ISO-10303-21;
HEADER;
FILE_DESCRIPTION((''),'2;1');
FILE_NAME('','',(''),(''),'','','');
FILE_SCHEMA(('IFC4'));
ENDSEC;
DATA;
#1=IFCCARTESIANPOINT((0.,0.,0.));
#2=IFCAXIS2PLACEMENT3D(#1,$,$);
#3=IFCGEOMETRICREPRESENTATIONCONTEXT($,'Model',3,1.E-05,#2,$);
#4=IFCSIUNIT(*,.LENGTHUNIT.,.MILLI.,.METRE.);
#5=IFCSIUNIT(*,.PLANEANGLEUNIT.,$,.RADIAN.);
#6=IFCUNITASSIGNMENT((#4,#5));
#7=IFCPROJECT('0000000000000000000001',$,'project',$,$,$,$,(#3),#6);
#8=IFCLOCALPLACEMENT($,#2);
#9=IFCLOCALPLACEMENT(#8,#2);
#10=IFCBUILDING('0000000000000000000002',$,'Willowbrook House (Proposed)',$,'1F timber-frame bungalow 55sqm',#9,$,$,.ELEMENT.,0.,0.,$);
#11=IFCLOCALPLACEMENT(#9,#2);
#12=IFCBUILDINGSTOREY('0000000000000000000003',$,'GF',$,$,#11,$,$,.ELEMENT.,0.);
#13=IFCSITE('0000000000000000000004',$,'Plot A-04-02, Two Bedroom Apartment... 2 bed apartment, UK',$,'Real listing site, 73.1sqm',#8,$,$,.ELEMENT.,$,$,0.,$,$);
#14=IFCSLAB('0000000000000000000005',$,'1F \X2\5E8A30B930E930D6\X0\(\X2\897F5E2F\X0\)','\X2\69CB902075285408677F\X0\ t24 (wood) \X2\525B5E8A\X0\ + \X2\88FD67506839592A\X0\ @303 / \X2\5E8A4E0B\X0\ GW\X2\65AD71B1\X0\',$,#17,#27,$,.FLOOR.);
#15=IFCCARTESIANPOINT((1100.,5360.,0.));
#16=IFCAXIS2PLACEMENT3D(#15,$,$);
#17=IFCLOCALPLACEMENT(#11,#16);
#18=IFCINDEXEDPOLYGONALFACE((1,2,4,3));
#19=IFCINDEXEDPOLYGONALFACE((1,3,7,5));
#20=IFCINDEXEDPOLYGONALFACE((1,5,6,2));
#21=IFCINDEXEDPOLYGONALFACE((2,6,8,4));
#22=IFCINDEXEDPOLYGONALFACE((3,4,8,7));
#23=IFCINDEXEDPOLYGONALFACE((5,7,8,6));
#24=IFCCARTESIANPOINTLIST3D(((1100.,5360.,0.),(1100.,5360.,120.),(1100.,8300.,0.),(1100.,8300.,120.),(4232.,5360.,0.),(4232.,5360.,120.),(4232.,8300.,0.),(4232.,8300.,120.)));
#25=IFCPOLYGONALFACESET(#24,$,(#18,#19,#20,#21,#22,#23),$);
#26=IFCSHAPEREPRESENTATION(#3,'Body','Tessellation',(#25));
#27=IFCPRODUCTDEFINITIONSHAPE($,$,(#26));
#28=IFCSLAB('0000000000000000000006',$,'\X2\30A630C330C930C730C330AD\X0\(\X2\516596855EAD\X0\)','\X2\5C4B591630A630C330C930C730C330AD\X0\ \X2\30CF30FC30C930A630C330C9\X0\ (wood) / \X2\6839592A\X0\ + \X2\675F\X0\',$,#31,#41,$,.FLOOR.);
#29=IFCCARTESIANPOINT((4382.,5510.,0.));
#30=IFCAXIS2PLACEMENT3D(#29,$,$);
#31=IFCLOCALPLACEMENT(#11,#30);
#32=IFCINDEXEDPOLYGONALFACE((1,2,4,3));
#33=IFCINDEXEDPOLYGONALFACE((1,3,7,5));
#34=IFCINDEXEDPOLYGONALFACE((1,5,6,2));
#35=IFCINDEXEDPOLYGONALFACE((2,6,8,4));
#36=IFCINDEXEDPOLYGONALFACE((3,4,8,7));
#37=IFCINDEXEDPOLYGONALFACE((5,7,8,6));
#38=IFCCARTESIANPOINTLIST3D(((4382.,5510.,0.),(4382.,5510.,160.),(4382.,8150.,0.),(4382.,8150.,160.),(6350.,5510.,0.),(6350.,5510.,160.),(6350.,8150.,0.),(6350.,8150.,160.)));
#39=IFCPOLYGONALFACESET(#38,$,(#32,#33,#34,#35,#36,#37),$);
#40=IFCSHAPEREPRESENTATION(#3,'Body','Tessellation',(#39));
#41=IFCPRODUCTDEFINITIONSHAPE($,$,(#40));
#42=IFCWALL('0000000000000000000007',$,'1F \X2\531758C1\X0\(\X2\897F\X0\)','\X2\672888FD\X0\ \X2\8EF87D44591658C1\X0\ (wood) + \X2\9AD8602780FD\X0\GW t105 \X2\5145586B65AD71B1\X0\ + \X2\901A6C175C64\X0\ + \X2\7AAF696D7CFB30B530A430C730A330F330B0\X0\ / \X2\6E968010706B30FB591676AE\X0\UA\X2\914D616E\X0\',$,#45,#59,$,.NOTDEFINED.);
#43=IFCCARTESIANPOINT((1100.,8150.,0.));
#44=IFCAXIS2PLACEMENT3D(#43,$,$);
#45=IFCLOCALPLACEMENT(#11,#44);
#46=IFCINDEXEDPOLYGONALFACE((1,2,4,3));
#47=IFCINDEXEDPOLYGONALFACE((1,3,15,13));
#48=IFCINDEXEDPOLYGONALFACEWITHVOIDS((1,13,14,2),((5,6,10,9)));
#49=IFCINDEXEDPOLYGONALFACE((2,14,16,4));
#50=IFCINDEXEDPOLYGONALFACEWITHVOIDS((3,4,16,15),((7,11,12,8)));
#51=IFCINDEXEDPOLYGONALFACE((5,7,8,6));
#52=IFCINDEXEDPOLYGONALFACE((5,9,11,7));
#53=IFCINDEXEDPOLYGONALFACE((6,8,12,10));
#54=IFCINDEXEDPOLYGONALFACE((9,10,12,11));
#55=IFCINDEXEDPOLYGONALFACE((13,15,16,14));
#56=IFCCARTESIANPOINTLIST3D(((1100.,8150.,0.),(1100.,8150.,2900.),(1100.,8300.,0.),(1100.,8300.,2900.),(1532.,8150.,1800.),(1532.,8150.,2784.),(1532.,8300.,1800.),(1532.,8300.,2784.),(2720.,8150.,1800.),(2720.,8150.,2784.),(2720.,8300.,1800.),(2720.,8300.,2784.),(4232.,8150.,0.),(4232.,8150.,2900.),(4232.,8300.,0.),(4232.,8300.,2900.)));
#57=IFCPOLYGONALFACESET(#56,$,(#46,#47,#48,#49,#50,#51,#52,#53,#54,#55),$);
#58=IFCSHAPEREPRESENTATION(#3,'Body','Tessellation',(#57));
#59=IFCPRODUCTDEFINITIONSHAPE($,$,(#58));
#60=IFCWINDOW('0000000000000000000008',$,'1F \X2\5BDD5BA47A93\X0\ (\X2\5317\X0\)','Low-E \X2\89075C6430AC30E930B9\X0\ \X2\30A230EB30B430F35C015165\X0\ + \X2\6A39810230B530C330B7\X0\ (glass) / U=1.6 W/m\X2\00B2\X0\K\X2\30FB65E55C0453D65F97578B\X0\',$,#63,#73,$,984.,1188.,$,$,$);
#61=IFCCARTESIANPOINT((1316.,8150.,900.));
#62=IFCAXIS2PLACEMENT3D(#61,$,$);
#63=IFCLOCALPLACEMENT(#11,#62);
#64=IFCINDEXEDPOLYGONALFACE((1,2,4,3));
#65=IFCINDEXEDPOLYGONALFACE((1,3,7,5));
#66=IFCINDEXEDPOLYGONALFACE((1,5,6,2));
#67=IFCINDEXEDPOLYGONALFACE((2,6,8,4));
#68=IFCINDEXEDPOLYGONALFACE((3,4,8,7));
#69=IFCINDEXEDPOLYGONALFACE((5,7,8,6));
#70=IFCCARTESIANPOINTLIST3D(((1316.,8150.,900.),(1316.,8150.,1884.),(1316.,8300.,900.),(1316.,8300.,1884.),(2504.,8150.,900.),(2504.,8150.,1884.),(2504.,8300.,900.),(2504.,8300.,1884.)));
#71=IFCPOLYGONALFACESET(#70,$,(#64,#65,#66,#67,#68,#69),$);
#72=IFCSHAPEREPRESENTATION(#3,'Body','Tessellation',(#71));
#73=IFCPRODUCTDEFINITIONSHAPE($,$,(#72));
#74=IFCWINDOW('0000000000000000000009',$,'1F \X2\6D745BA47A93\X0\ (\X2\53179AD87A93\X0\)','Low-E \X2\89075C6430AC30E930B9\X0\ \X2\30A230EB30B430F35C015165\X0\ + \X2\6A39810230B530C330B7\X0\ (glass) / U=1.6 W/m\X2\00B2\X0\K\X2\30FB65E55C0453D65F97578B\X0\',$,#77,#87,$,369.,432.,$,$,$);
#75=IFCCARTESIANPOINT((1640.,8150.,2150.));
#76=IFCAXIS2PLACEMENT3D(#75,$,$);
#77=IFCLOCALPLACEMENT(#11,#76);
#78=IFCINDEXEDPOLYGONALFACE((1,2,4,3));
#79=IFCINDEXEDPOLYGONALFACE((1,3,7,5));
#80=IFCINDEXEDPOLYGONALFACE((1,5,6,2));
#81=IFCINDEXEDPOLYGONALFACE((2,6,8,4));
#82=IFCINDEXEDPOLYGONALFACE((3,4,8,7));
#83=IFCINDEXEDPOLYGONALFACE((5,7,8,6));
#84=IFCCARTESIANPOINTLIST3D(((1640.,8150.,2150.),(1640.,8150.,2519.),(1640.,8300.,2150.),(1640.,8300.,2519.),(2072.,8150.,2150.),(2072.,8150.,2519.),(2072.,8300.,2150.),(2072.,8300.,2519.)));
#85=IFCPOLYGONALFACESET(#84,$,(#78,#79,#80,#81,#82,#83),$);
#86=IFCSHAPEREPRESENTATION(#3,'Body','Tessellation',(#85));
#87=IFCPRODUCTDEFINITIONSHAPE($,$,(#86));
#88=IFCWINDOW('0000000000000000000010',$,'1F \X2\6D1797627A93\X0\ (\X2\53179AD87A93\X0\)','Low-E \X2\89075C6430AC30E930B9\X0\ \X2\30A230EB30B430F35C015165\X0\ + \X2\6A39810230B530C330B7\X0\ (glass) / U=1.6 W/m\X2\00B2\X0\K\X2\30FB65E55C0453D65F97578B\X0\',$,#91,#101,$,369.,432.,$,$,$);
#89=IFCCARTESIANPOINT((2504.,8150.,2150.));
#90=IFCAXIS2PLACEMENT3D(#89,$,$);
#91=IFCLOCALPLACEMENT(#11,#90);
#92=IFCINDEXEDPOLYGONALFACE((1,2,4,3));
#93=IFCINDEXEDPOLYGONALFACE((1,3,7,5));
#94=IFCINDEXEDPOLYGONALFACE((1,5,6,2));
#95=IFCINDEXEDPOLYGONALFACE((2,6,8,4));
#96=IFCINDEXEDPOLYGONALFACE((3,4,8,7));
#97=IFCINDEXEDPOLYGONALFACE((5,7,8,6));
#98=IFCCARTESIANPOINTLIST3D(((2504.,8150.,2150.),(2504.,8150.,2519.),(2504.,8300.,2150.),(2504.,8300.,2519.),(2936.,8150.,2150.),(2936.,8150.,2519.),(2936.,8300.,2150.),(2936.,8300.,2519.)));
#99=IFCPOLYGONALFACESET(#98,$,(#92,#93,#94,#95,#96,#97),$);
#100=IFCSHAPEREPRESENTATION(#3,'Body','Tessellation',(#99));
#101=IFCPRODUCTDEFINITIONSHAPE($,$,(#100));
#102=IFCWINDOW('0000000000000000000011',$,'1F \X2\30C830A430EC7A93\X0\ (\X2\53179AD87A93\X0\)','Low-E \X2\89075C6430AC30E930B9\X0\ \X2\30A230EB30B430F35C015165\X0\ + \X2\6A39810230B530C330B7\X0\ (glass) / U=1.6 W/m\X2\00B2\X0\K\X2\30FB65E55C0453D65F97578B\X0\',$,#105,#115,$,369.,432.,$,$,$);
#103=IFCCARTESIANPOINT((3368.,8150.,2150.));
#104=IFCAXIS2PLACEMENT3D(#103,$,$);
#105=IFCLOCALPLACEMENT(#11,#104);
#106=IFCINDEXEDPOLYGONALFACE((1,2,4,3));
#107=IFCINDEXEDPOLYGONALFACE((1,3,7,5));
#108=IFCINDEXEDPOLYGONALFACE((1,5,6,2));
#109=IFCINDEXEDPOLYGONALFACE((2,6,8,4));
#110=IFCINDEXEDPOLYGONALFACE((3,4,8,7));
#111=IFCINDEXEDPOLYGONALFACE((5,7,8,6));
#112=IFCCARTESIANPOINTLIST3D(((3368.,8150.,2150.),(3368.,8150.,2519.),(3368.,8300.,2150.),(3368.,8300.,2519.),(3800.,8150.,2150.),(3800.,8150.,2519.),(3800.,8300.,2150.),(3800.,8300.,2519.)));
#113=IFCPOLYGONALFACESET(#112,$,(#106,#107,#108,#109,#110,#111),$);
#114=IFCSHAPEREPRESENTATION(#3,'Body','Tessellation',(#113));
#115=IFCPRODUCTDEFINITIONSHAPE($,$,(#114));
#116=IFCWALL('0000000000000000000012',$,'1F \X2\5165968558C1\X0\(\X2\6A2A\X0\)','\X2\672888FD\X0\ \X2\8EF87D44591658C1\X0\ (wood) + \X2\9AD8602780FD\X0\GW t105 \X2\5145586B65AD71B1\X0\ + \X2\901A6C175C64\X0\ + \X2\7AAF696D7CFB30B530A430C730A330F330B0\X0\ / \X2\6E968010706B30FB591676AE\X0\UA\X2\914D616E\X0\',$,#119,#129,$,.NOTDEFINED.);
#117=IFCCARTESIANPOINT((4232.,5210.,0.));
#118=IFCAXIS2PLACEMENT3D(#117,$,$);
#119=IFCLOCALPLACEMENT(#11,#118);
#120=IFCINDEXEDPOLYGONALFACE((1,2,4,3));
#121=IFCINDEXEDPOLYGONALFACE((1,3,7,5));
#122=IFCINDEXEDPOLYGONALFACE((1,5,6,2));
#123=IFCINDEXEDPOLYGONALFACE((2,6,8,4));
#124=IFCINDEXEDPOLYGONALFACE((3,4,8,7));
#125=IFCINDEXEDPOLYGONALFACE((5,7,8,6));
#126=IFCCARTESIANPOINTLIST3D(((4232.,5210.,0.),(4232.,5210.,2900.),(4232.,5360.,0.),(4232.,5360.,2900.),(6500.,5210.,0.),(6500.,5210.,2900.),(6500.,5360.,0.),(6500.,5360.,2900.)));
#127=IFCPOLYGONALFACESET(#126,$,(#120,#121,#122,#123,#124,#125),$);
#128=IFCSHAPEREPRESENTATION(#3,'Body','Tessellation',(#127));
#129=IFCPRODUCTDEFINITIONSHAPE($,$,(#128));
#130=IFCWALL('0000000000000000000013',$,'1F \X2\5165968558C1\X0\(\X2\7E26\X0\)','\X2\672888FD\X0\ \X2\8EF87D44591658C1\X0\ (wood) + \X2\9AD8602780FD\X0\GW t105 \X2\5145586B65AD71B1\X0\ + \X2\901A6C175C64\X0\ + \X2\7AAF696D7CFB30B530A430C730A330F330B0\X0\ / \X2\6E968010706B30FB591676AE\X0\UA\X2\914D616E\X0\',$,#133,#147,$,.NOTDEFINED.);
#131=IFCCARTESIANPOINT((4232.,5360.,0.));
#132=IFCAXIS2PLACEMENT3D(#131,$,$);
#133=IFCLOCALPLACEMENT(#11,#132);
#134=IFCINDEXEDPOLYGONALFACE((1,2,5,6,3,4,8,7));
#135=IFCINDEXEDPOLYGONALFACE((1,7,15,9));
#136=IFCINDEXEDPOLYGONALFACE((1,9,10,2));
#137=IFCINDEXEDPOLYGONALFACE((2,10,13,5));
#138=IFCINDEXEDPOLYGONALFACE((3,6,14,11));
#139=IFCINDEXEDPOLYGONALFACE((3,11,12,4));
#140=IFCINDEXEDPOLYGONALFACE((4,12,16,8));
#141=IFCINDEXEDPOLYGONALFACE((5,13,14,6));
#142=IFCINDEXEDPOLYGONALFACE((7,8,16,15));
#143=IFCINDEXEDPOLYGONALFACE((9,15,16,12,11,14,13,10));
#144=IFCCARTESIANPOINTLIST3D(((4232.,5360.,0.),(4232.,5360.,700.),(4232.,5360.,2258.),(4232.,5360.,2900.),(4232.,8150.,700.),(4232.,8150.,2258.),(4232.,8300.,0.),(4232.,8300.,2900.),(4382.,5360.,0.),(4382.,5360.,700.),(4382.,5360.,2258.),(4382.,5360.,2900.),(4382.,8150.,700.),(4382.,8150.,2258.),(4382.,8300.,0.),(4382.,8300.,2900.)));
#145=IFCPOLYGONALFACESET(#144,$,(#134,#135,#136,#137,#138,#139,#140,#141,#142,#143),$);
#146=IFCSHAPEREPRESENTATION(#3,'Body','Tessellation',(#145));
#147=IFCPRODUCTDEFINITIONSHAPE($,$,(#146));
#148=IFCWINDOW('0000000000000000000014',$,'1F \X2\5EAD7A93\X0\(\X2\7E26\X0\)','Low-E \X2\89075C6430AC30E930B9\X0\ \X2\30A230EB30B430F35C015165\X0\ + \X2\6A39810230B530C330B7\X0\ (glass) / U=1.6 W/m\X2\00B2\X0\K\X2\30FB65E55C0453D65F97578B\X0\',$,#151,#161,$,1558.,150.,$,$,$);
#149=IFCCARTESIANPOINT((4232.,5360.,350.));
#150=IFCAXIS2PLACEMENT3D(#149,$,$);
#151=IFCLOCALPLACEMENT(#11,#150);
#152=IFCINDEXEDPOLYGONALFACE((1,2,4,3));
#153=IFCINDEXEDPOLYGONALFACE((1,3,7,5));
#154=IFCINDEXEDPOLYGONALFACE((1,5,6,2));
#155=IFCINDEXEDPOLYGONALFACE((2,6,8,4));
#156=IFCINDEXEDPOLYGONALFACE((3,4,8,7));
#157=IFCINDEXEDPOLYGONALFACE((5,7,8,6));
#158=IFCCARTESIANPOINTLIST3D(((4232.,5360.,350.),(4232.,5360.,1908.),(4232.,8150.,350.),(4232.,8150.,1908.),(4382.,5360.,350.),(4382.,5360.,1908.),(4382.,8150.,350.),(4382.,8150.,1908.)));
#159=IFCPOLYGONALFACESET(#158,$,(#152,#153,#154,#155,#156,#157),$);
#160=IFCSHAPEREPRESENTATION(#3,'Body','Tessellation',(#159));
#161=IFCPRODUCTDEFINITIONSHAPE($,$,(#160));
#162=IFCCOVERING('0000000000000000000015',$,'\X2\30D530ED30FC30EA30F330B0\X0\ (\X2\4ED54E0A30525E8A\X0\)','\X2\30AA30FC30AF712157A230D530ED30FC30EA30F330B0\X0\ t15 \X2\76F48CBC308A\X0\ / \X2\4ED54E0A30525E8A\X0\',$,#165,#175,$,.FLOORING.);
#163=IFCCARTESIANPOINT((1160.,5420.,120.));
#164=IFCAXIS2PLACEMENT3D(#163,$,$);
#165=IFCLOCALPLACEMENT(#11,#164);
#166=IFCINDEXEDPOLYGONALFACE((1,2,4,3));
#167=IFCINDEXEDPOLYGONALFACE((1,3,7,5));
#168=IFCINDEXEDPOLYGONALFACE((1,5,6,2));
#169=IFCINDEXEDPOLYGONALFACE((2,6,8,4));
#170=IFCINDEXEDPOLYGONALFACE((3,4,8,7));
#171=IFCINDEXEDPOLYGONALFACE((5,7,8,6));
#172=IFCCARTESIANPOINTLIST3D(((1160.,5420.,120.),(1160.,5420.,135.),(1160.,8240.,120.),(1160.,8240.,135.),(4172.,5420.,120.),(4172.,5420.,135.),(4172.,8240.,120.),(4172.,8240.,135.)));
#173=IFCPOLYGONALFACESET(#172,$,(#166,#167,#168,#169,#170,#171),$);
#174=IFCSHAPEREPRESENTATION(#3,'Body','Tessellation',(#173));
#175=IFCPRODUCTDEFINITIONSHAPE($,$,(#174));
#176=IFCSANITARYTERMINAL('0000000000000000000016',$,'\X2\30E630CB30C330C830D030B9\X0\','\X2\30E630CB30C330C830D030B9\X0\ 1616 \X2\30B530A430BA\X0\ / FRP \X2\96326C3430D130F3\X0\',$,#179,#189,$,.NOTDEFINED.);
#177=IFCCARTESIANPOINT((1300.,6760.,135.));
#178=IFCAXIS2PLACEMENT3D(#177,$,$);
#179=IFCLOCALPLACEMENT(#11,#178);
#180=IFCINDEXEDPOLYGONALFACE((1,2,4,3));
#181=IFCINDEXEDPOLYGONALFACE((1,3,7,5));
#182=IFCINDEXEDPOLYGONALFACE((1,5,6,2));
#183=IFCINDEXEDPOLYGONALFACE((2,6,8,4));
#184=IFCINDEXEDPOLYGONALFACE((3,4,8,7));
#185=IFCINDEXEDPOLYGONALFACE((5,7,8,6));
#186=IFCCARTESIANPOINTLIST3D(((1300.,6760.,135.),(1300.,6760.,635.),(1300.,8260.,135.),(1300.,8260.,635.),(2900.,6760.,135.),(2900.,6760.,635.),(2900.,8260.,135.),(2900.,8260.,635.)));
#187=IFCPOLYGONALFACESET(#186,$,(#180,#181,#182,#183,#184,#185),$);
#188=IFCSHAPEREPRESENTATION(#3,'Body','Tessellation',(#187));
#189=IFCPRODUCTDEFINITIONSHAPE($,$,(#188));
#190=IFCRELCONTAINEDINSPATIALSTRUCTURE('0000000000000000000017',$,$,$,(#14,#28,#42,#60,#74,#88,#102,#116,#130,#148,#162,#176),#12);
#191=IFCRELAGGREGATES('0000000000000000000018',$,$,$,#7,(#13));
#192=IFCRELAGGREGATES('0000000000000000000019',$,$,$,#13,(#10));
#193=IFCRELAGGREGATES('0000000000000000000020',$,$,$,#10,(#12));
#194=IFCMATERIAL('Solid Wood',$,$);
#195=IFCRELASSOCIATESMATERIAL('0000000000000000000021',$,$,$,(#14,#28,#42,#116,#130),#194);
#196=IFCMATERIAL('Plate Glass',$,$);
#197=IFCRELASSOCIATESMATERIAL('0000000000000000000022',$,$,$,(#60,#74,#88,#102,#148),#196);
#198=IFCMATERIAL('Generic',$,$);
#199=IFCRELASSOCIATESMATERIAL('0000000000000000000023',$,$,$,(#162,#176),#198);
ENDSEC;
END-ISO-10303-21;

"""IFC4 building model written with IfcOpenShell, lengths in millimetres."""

from ifc_helpers import new_model, si_unit, frame, frame_2d, origin, place, context, project, spatial, rectangle, extrude, material, element, fill, save


model = new_model("IFC4")

# Units and contexts
model_context = context("Model", 3, precision=1e-05, world=origin())
ifc_project = project(units=[si_unit("LENGTHUNIT", "METRE", prefix="MILLI"), si_unit("PLANEANGLEUNIT", "RADIAN")], contexts=[model_context])

# Site, building, storey
site_placement = place(None, origin())
site = spatial("IfcSite", under=ifc_project, at=site_placement, Name="Plot A-04-02, Two Bedroom Apartment... 2 bed apartment, UK", ObjectType="Real listing site, 73.1sqm", CompositionType="ELEMENT", RefElevation=0.0)
building_placement = place(site_placement, origin())
building = spatial("IfcBuilding", under=site, at=building_placement, Name="Willowbrook House (Proposed)", ObjectType="1F timber-frame bungalow 55sqm", CompositionType="ELEMENT", ElevationOfRefHeight=0.0, ElevationOfTerrain=0.0)
storey_placement = place(building_placement, origin())
storey = spatial("IfcBuildingStorey", under=building, at=storey_placement, Name="GF", CompositionType="ELEMENT", Elevation=0.0)

# Slabs
ifc_material_1 = material(Name="Solid Wood")
slab_1_placement = place(storey_placement, frame((1100.0, 5360.0, 0.0)))
element("IfcSlab", 1, at=slab_1_placement, inside=storey, material=ifc_material_1, Name="1F 床スラブ(西帯)", Description="構造用合板 t24 (wood) 剛床 + 製材根太 @303 / 床下 GW断熱", PredefinedType="FLOOR", context=model_context, shape_type="SweptSolid", body=[
    extrude(rectangle(XDim=3132.0, YDim=2940.0, at=frame_2d((1566.0, 1470.0))), frame((1100.0, 5360.0, 0.0)), (0.0, 0.0, 1.0), 120.0),
])
slab_2_placement = place(storey_placement, frame((4382.0, 5510.0, 0.0)))
element("IfcSlab", 2, at=slab_2_placement, inside=storey, material=ifc_material_1, Name="ウッドデッキ(入隅庭)", Description="屋外ウッドデッキ ハードウッド (wood) / 根太 + 束", PredefinedType="FLOOR", context=model_context, shape_type="SweptSolid", body=[
    extrude(rectangle(XDim=1968.0, YDim=2640.0, at=frame_2d((984.0, 1320.0))), frame((4382.0, 5510.0, 0.0)), (0.0, 0.0, 1.0), 160.0),
])

# Wall, openings, windows
wall_1_placement = place(storey_placement, frame((1100.0, 8150.0, 0.0)))
wall_1 = element("IfcWall", 3, at=wall_1_placement, inside=storey, material=ifc_material_1, Name="1F 北壁(西)", Description="木製 軸組外壁 (wood) + 高性能GW t105 充填断熱 + 通気層 + 窯業系サイディング / 準耐火・外皮UA配慮", PredefinedType="NOTDEFINED", context=model_context, shape_type="SweptSolid", body=[
    extrude(rectangle(XDim=3132.0, YDim=150.0, at=frame_2d((1566.0, 75.0))), frame((1100.0, 8150.0, 0.0)), (0.0, 0.0, 1.0), 2900.0),
])
opening_1_placement = place(storey_placement, frame((1316.0, 8150.0, 900.0)))
opening_1 = element("IfcOpeningElement", 4, at=opening_1_placement, cuts=wall_1, PredefinedType="NOTDEFINED", context=model_context, shape_type="SweptSolid", body=[
    extrude(rectangle(XDim=1188.0, YDim=150.0, at=frame_2d((594.0, 75.0))), frame((1316.0, 8150.0, 900.0)), (0.0, 0.0, 1.0), 984.0),
])
opening_2_placement = place(storey_placement, frame((1640.0, 8150.0, 2150.0)))
opening_2 = element("IfcOpeningElement", 5, at=opening_2_placement, cuts=wall_1, PredefinedType="NOTDEFINED", context=model_context, shape_type="SweptSolid", body=[
    extrude(rectangle(XDim=432.0, YDim=150.0, at=frame_2d((216.0, 75.0))), frame((1640.0, 8150.0, 2150.0)), (0.0, 0.0, 1.0), 369.0),
])
opening_3_placement = place(storey_placement, frame((2504.0, 8150.0, 2150.0)))
opening_3 = element("IfcOpeningElement", 6, at=opening_3_placement, cuts=wall_1, PredefinedType="NOTDEFINED", context=model_context, shape_type="SweptSolid", body=[
    extrude(rectangle(XDim=432.0, YDim=150.0, at=frame_2d((216.0, 75.0))), frame((2504.0, 8150.0, 2150.0)), (0.0, 0.0, 1.0), 369.0),
])
opening_4_placement = place(storey_placement, frame((3368.0, 8150.0, 2150.0)))
opening_4 = element("IfcOpeningElement", 7, at=opening_4_placement, cuts=wall_1, PredefinedType="NOTDEFINED", context=model_context, shape_type="SweptSolid", body=[
    extrude(rectangle(XDim=432.0, YDim=150.0, at=frame_2d((216.0, 75.0))), frame((3368.0, 8150.0, 2150.0)), (0.0, 0.0, 1.0), 369.0),
])
ifc_material_2 = material(Name="Plate Glass")
window_1_placement = place(storey_placement, frame((1316.0, 8150.0, 900.0)))
window_1 = element("IfcWindow", 8, at=window_1_placement, inside=storey, material=ifc_material_2, Name="1F 寝室窓 (北)", Description="Low-E 複層ガラス アルゴン封入 + 樹脂サッシ (glass) / U=1.6 W/m²K・日射取得型", OverallHeight=984.0, OverallWidth=1188.0, context=model_context, shape_type="SweptSolid", body=[
    extrude(rectangle(XDim=1188.0, YDim=150.0, at=frame_2d((594.0, 75.0))), frame((1316.0, 8150.0, 900.0)), (0.0, 0.0, 1.0), 984.0),
])
fill(opening_1, window_1)
window_2_placement = place(storey_placement, frame((1640.0, 8150.0, 2150.0)))
window_2 = element("IfcWindow", 9, at=window_2_placement, inside=storey, material=ifc_material_2, Name="1F 浴室窓 (北高窓)", Description="Low-E 複層ガラス アルゴン封入 + 樹脂サッシ (glass) / U=1.6 W/m²K・日射取得型", OverallHeight=369.0, OverallWidth=432.0, context=model_context, shape_type="SweptSolid", body=[
    extrude(rectangle(XDim=432.0, YDim=150.0, at=frame_2d((216.0, 75.0))), frame((1640.0, 8150.0, 2150.0)), (0.0, 0.0, 1.0), 369.0),
])
fill(opening_2, window_2)
window_3_placement = place(storey_placement, frame((2504.0, 8150.0, 2150.0)))
window_3 = element("IfcWindow", 10, at=window_3_placement, inside=storey, material=ifc_material_2, Name="1F 洗面窓 (北高窓)", Description="Low-E 複層ガラス アルゴン封入 + 樹脂サッシ (glass) / U=1.6 W/m²K・日射取得型", OverallHeight=369.0, OverallWidth=432.0, context=model_context, shape_type="SweptSolid", body=[
    extrude(rectangle(XDim=432.0, YDim=150.0, at=frame_2d((216.0, 75.0))), frame((2504.0, 8150.0, 2150.0)), (0.0, 0.0, 1.0), 369.0),
])
fill(opening_3, window_3)
window_4_placement = place(storey_placement, frame((3368.0, 8150.0, 2150.0)))
window_4 = element("IfcWindow", 11, at=window_4_placement, inside=storey, material=ifc_material_2, Name="1F トイレ窓 (北高窓)", Description="Low-E 複層ガラス アルゴン封入 + 樹脂サッシ (glass) / U=1.6 W/m²K・日射取得型", OverallHeight=369.0, OverallWidth=432.0, context=model_context, shape_type="SweptSolid", body=[
    extrude(rectangle(XDim=432.0, YDim=150.0, at=frame_2d((216.0, 75.0))), frame((3368.0, 8150.0, 2150.0)), (0.0, 0.0, 1.0), 369.0),
])
fill(opening_4, window_4)

# Wall
wall_2_placement = place(storey_placement, frame((4232.0, 5210.0, 0.0)))
element("IfcWall", 12, at=wall_2_placement, inside=storey, material=ifc_material_1, Name="1F 入隅壁(横)", Description="木製 軸組外壁 (wood) + 高性能GW t105 充填断熱 + 通気層 + 窯業系サイディング / 準耐火・外皮UA配慮", PredefinedType="NOTDEFINED", context=model_context, shape_type="SweptSolid", body=[
    extrude(rectangle(XDim=2268.0, YDim=150.0, at=frame_2d((1134.0, 75.0))), frame((4232.0, 5210.0, 0.0)), (0.0, 0.0, 1.0), 2900.0),
])

# Wall, opening, window
wall_3_placement = place(storey_placement, frame((4232.0, 5360.0, 0.0)))
wall_3 = element("IfcWall", 13, at=wall_3_placement, inside=storey, material=ifc_material_1, Name="1F 入隅壁(縦)", Description="木製 軸組外壁 (wood) + 高性能GW t105 充填断熱 + 通気層 + 窯業系サイディング / 準耐火・外皮UA配慮", PredefinedType="NOTDEFINED", context=model_context, shape_type="SweptSolid", body=[
    extrude(rectangle(XDim=150.0, YDim=2940.0, at=frame_2d((75.0, 1470.0))), frame((4232.0, 5360.0, 0.0)), (0.0, 0.0, 1.0), 2900.0),
])
opening_5_placement = place(storey_placement, frame((4232.0, 5360.0, 350.0)))
opening_5 = element("IfcOpeningElement", 14, at=opening_5_placement, cuts=wall_3, PredefinedType="NOTDEFINED", context=model_context, shape_type="SweptSolid", body=[
    extrude(rectangle(XDim=150.0, YDim=2790.0, at=frame_2d((75.0, 1395.0))), frame((4232.0, 5360.0, 350.0)), (0.0, 0.0, 1.0), 1558.0),
])
window_5_placement = place(storey_placement, frame((4232.0, 5360.0, 350.0)))
window_5 = element("IfcWindow", 15, at=window_5_placement, inside=storey, material=ifc_material_2, Name="1F 庭窓(縦)", Description="Low-E 複層ガラス アルゴン封入 + 樹脂サッシ (glass) / U=1.6 W/m²K・日射取得型", OverallHeight=1558.0, OverallWidth=150.0, context=model_context, shape_type="SweptSolid", body=[
    extrude(rectangle(XDim=150.0, YDim=2790.0, at=frame_2d((75.0, 1395.0))), frame((4232.0, 5360.0, 350.0)), (0.0, 0.0, 1.0), 1558.0),
])
fill(opening_5, window_5)

# Covering
ifc_material_3 = material(Name="Generic")
covering_placement = place(storey_placement, frame((1160.0, 5420.0, 120.0)))
element("IfcCovering", 16, at=covering_placement, inside=storey, material=ifc_material_3, Name="フローリング (仕上げ床)", Description="オーク無垢フローリング t15 直貼り / 仕上げ床", PredefinedType="FLOORING", context=model_context, shape_type="SweptSolid", body=[
    extrude(rectangle(XDim=3012.0, YDim=2820.0, at=frame_2d((1506.0, 1410.0))), frame((1160.0, 5420.0, 120.0)), (0.0, 0.0, 1.0), 15.0),
])

# Sanitary terminal
sanitary_terminal_1_placement = place(storey_placement, frame((1300.0, 6760.0, 135.0)))
element("IfcSanitaryTerminal", 17, at=sanitary_terminal_1_placement, inside=storey, material=ifc_material_3, Name="ユニットバス", Description="ユニットバス 1616 サイズ / FRP 防水パン", PredefinedType="NOTDEFINED", context=model_context, shape_type="SweptSolid", body=[
    extrude(rectangle(XDim=1600.0, YDim=1500.0, at=frame_2d((800.0, 750.0))), frame((1300.0, 6760.0, 135.0)), (0.0, 0.0, 1.0), 500.0),
])

save(model, "model.ifc")
